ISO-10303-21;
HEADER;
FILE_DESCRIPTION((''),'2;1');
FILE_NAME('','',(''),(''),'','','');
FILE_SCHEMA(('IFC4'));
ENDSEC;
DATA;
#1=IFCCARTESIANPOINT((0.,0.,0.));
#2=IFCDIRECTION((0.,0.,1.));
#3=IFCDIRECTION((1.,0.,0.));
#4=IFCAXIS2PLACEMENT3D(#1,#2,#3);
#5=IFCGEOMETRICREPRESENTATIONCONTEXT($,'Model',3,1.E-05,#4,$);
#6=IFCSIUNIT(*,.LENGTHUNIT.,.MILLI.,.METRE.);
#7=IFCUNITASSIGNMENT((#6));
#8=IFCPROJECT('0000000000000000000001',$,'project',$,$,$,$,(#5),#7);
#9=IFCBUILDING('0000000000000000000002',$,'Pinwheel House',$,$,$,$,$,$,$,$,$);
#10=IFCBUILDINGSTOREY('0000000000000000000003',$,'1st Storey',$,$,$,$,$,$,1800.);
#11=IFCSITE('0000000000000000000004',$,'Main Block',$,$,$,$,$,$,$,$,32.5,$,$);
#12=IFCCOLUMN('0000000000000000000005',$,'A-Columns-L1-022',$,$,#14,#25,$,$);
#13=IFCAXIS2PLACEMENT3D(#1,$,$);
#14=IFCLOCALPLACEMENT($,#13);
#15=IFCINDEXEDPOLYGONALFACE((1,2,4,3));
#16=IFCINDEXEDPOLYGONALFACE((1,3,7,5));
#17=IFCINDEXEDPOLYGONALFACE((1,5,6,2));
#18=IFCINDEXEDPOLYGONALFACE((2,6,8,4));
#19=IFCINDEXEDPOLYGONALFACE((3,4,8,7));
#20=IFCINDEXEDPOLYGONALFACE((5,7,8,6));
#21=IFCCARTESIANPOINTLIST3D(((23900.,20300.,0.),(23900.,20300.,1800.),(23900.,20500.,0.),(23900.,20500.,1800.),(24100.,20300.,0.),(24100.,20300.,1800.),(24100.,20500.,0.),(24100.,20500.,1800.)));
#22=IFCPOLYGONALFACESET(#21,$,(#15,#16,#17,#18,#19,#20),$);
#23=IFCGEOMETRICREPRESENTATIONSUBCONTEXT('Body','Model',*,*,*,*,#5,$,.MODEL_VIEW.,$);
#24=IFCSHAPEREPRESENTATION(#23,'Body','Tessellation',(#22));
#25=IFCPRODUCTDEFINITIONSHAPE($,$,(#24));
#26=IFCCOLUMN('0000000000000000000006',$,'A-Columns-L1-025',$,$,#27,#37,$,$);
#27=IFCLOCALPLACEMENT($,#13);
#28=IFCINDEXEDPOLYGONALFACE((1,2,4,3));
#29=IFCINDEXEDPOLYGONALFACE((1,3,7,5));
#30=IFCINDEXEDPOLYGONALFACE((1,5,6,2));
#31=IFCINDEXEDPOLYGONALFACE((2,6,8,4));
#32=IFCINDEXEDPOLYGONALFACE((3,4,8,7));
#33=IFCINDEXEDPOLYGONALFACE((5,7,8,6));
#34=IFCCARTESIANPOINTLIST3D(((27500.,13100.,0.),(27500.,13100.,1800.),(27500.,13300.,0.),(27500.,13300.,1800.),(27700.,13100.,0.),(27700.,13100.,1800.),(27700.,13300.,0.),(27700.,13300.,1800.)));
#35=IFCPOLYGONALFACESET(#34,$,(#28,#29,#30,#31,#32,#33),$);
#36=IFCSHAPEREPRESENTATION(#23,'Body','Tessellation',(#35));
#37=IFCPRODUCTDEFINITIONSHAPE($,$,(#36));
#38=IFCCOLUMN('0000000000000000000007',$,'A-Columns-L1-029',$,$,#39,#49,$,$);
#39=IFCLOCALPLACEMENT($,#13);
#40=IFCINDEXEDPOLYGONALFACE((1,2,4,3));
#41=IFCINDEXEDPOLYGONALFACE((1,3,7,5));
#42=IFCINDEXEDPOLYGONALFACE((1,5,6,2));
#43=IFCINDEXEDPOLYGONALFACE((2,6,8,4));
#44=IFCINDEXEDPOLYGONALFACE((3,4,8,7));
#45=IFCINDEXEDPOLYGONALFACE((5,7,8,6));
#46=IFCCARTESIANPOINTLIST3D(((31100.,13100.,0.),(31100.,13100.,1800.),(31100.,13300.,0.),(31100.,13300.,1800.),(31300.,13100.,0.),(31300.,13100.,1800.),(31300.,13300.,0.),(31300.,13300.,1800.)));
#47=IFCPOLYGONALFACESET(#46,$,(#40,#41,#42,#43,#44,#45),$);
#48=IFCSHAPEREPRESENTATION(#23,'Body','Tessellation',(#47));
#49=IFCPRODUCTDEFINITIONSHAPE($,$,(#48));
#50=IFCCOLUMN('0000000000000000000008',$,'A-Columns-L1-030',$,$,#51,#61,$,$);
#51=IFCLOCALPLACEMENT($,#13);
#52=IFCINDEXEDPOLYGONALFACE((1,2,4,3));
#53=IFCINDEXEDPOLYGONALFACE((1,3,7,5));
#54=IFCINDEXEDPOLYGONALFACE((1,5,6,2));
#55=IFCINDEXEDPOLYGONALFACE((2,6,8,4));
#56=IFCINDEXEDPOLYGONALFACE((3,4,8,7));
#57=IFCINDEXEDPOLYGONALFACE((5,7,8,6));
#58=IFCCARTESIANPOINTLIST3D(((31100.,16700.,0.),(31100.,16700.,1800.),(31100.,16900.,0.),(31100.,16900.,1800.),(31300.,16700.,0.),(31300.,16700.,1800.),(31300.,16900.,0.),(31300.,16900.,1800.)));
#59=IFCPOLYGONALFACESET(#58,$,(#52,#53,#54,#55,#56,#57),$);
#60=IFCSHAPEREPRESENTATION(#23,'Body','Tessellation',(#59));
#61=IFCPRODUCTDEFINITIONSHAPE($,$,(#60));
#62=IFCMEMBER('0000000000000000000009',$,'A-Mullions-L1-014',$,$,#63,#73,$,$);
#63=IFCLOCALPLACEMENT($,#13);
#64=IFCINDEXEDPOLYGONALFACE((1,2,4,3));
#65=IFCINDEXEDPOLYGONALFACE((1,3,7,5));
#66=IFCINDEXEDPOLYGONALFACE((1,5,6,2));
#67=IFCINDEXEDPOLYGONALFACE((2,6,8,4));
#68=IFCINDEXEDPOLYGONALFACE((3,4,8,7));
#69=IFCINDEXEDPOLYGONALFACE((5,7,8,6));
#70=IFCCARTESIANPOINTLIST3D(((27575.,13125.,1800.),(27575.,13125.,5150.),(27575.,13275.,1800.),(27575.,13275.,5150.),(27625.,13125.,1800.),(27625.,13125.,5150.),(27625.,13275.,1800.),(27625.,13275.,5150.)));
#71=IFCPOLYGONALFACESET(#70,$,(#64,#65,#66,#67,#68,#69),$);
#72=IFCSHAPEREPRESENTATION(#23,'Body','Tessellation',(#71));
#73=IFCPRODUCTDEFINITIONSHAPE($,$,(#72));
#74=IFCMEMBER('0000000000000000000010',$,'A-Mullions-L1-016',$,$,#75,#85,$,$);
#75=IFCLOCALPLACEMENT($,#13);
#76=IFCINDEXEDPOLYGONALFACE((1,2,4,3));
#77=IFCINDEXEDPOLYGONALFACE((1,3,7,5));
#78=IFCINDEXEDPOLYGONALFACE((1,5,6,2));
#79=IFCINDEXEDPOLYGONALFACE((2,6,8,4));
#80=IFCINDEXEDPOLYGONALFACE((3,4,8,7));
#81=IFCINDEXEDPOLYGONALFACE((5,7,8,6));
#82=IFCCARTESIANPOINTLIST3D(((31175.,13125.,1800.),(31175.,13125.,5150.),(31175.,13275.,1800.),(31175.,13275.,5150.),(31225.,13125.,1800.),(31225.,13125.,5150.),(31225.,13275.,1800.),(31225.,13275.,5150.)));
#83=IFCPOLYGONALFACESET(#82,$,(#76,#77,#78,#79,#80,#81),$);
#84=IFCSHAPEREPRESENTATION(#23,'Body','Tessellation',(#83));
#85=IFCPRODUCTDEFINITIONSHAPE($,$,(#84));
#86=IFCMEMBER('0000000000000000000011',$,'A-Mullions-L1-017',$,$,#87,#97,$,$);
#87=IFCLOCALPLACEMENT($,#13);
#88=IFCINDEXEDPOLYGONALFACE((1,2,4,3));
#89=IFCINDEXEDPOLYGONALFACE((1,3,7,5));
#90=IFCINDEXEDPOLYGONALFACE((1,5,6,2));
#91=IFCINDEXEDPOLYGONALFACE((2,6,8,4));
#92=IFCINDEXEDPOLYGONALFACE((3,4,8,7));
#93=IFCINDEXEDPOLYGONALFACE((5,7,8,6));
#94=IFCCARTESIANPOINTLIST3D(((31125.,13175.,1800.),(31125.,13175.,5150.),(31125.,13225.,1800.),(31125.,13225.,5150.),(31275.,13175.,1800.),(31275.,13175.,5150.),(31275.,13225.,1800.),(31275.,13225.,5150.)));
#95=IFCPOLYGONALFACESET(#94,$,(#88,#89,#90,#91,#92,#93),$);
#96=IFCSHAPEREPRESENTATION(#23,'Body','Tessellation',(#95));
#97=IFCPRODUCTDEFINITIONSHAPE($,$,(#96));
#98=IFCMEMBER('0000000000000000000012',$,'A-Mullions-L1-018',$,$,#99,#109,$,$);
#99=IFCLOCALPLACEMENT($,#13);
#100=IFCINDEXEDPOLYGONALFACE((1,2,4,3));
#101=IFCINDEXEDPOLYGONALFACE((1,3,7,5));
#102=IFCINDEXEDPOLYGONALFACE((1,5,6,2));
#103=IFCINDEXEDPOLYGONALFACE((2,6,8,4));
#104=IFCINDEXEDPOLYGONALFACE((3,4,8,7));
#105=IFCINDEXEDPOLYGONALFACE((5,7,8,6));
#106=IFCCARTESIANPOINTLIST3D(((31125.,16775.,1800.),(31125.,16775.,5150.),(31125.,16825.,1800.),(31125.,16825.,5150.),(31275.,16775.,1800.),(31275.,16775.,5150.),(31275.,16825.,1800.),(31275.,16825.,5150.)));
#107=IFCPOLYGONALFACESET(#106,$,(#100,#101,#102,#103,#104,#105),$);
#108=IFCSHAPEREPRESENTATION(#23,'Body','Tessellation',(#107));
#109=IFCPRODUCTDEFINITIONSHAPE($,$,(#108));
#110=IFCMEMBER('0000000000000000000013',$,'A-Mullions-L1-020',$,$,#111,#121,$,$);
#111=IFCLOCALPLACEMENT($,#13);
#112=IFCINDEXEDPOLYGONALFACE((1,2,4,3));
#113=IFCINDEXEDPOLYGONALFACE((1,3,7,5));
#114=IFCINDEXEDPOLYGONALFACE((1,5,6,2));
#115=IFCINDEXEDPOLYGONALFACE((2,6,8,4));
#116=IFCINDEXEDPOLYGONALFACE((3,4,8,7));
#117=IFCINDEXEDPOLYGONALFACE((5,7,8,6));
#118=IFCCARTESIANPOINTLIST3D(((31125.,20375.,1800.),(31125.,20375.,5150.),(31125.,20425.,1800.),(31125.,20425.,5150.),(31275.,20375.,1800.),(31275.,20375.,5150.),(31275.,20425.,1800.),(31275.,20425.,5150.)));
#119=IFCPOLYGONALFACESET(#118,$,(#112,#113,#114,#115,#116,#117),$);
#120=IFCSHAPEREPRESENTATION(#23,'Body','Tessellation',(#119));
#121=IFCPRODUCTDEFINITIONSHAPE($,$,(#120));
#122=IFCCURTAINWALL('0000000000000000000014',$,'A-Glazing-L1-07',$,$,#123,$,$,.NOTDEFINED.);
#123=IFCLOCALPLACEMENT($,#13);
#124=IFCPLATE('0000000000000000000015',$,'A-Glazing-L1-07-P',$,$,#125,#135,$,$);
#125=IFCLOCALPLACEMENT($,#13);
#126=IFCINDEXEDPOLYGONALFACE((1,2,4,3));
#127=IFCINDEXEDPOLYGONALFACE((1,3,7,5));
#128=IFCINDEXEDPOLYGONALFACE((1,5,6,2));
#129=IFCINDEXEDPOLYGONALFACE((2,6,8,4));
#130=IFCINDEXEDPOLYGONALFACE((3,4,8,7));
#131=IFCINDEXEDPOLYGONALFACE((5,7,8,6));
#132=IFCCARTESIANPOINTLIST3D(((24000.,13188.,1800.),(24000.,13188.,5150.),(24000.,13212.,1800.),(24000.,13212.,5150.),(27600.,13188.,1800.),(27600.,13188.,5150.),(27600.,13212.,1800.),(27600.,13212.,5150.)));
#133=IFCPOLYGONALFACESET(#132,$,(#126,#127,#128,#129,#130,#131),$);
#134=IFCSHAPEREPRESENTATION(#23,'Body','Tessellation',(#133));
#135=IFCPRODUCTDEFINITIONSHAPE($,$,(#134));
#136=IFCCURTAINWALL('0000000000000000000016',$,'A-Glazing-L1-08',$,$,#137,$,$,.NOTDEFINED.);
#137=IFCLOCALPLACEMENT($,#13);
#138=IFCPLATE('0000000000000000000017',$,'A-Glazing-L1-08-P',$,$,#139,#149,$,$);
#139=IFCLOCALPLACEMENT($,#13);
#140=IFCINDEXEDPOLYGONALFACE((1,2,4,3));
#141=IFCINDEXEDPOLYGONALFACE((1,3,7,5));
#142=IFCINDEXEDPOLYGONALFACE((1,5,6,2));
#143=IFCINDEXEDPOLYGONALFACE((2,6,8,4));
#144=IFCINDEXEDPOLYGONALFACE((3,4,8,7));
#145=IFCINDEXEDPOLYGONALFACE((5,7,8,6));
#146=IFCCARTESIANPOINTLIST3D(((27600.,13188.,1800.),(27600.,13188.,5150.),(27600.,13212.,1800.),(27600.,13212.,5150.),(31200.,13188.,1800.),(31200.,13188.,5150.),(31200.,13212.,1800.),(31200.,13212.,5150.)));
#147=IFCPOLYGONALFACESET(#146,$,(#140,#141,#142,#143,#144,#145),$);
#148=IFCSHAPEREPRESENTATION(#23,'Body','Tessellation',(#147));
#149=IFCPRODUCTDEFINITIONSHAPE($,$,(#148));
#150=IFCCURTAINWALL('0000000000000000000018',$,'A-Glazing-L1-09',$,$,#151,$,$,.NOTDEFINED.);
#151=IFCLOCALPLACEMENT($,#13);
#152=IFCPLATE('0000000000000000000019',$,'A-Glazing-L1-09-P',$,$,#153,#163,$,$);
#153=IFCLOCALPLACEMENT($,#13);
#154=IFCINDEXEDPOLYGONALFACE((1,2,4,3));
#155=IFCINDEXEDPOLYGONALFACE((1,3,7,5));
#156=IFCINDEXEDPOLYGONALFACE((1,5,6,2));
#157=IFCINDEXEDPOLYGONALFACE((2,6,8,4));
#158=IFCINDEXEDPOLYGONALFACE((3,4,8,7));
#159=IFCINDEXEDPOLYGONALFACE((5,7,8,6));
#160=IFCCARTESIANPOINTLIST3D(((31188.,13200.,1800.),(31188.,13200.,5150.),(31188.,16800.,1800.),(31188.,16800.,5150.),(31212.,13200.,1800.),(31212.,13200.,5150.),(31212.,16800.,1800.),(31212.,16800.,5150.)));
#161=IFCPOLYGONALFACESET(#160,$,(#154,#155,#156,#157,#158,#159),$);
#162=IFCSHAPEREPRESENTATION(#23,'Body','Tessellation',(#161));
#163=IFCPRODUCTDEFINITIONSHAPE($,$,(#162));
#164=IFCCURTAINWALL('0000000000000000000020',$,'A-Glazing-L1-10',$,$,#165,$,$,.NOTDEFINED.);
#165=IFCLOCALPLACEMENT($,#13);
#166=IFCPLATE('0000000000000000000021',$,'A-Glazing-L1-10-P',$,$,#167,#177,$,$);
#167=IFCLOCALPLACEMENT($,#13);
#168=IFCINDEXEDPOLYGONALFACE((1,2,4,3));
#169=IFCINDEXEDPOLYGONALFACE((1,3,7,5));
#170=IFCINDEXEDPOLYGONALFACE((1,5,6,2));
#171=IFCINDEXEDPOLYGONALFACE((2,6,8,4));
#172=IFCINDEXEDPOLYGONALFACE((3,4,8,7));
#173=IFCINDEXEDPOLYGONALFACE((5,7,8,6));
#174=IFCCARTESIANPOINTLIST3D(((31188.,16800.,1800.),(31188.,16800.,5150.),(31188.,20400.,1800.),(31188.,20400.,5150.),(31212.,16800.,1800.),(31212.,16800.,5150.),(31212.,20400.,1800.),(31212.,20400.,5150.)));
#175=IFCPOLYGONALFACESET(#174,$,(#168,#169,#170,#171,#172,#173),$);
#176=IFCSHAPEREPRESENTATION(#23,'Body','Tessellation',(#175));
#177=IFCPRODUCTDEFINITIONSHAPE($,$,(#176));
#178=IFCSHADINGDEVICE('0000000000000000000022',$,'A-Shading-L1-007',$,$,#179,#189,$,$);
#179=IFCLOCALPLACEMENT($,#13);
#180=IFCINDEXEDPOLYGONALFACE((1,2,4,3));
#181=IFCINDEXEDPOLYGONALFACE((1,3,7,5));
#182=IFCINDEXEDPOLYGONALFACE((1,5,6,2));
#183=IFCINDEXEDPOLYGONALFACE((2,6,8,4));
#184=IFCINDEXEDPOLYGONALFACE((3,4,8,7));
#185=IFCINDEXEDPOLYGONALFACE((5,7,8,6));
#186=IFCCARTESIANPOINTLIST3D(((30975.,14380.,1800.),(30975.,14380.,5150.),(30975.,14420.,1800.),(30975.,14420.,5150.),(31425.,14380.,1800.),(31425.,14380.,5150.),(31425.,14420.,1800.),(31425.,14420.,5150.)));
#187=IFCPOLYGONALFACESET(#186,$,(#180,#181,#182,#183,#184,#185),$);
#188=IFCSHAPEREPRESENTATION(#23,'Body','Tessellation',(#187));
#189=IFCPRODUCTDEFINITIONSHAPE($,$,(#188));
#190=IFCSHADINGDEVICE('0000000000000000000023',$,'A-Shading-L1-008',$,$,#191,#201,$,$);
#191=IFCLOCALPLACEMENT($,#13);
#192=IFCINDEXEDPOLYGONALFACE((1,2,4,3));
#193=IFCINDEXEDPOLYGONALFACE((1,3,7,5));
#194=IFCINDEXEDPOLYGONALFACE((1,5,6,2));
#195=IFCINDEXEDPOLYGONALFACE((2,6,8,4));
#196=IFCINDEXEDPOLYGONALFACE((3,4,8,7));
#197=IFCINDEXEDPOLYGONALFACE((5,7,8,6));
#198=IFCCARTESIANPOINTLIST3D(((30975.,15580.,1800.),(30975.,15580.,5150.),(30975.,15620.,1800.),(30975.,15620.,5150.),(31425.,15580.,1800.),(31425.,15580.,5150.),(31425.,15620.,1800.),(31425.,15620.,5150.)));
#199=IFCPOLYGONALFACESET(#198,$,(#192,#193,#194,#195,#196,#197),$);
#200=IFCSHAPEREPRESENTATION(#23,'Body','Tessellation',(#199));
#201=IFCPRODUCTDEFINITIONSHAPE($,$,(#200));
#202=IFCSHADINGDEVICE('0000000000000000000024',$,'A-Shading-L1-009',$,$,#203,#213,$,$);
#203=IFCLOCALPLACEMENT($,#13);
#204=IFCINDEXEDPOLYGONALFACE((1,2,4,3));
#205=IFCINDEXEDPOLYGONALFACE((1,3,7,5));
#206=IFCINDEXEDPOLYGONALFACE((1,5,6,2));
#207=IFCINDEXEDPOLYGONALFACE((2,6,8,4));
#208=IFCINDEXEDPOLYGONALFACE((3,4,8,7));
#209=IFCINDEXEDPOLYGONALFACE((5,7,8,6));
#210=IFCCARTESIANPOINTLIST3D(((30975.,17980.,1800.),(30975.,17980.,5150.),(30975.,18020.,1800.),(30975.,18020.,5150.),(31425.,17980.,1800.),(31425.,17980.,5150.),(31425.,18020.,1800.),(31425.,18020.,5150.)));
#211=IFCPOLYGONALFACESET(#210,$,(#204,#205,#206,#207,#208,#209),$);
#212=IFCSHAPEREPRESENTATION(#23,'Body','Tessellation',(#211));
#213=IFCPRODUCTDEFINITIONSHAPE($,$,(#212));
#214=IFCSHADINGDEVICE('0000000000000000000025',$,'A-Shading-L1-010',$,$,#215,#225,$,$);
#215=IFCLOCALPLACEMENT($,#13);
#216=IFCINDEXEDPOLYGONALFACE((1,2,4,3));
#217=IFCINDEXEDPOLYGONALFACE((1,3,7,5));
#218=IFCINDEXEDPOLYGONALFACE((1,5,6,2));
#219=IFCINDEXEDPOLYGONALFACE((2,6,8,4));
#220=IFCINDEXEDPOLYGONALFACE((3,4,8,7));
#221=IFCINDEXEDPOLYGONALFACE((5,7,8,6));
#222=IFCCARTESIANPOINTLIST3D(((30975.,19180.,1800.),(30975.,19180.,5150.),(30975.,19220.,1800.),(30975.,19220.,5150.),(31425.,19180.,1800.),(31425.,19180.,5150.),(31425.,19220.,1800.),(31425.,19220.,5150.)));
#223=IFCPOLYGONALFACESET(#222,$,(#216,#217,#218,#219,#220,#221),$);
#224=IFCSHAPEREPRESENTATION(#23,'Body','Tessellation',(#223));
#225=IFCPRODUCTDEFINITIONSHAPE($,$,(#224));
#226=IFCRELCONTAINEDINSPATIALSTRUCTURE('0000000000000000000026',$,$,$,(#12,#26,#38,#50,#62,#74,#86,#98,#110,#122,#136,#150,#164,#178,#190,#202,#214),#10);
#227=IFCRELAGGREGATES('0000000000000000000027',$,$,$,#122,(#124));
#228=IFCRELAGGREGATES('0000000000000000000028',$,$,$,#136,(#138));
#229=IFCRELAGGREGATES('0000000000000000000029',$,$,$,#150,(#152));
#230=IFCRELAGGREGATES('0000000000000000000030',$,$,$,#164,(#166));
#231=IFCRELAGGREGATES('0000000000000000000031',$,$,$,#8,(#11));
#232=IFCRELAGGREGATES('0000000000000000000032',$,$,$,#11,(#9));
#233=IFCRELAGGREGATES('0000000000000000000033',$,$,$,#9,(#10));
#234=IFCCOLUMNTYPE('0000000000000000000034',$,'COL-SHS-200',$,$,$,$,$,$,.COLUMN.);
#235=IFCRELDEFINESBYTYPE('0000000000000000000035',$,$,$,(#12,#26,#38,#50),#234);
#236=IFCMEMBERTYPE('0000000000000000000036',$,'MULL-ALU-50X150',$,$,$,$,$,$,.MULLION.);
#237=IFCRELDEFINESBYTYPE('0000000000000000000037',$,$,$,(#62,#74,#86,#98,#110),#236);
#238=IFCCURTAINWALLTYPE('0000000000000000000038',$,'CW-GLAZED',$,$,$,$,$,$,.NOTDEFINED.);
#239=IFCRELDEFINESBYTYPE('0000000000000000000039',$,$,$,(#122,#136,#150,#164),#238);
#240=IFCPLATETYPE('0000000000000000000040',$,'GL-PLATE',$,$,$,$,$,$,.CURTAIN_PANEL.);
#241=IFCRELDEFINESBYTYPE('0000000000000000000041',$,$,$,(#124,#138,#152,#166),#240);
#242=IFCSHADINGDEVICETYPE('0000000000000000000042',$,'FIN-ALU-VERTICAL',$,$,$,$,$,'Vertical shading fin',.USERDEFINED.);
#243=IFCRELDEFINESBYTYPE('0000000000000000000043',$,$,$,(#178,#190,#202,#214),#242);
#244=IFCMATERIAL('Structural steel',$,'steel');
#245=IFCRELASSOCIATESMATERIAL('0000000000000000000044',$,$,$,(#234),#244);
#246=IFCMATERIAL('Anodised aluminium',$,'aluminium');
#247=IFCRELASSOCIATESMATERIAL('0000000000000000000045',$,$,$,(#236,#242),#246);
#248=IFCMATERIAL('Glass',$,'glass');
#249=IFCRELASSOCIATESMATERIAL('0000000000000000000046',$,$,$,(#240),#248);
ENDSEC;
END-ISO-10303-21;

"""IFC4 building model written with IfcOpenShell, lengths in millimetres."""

from ifc_helpers import new_model, si_unit, frame, origin_with_axes, place, context, subcontext, project, spatial, indexed_curve, outline, extrude, material, type_object, element, aggregate, save


model = new_model("IFC4")

# Units and contexts
model_context = context("Model", 3, precision=1e-05, world=origin_with_axes())
body_context = subcontext(model_context, "Body", "Model", "MODEL_VIEW")
ifc_project = project(units=[si_unit("LENGTHUNIT", "METRE", prefix="MILLI")], contexts=[model_context])

# Site, building, storey
site = spatial("IfcSite", under=ifc_project, Name="Main Block", RefElevation=32.5)
building = spatial("IfcBuilding", under=site, Name="Pinwheel House")
storey = spatial("IfcBuildingStorey", under=building, Name="1st Storey", Elevation=1800.0)

# Columns
ifc_material_1 = material(Name="Structural steel", Category="steel")
column_type = type_object("IfcColumnType", Name="COL-SHS-200", PredefinedType="COLUMN", material=ifc_material_1)
for number, where, z_axis, x_axis, name in (
    (1, (24000.0, 20400.0, 0.0), (0.0, 0.0, 1.0), (1.0, 0.0, 0.0), "A-Columns-L1-022"),
    (2, (27600.0, 13200.0, 0.0), (0.0, 0.0, 1.0), (1.0, 0.0, 0.0), "A-Columns-L1-025"),
    (3, (31200.0, 13200.0, 0.0), (0.0, 0.0, 1.0), (1.0, 0.0, 0.0), "A-Columns-L1-029"),
    (4, (31200.0, 16800.0, 0.0), (0.0, 0.0, 1.0), (1.0, 0.0, 0.0), "A-Columns-L1-030"),
):
    element("IfcColumn", number, at=place(None, frame(where, z_axis=z_axis, x_axis=x_axis)), inside=storey, type_object=column_type, Name=name, context=body_context, shape_type="SweptSolid", body=[
        extrude(outline(indexed_curve([(-100.0, -100.0), (100.0, -100.0), (100.0, 100.0), (-100.0, 100.0)])), None, (0.0, 0.0, 1.0), 1800.0),
    ])

# Members
ifc_material_2 = material(Name="Anodised aluminium", Category="aluminium")
member_type = type_object("IfcMemberType", Name="MULL-ALU-50X150", PredefinedType="MULLION", material=ifc_material_2)
for number, where, z_axis, x_axis, name in (
    (5, (27600.0, 13200.0, 1800.0), (0.0, 0.0, 1.0), (1.0, 0.0, 0.0), "A-Mullions-L1-014"),
    (6, (31200.0, 13200.0, 1800.0), (0.0, 0.0, 1.0), (1.0, 0.0, 0.0), "A-Mullions-L1-016"),
    (7, (31200.0, 13200.0, 1800.0), (0.0, 0.0, 1.0), (0.0, 1.0, 0.0), "A-Mullions-L1-017"),
    (8, (31200.0, 16800.0, 1800.0), (0.0, 0.0, 1.0), (0.0, 1.0, 0.0), "A-Mullions-L1-018"),
    (9, (31200.0, 20400.0, 1800.0), (0.0, 0.0, 1.0), (0.0, 1.0, 0.0), "A-Mullions-L1-020"),
):
    element("IfcMember", number, at=place(None, frame(where, z_axis=z_axis, x_axis=x_axis)), inside=storey, type_object=member_type, Name=name, context=body_context, shape_type="SweptSolid", body=[
        extrude(outline(indexed_curve([(-25.0, -75.0), (25.0, -75.0), (25.0, 75.0), (-25.0, 75.0)])), None, (0.0, 0.0, 1.0), 3350.0),
    ])

# Curtain walls, plates
curtain_wall_type = type_object("IfcCurtainWallType", Name="CW-GLAZED", PredefinedType="NOTDEFINED")
curtain_wall_1 = element("IfcCurtainWall", 10, inside=storey, type_object=curtain_wall_type, Name="A-Glazing-L1-07", PredefinedType="NOTDEFINED")
ifc_material_3 = material(Name="Glass", Category="glass")
plate_type = type_object("IfcPlateType", Name="GL-PLATE", PredefinedType="CURTAIN_PANEL", material=ifc_material_3)
plate_1_placement = place(None, frame((25800.0, 13200.0, 1800.0), z_axis=(0.0, 0.0, 1.0), x_axis=(1.0, 0.0, 0.0)))
plate_1 = element("IfcPlate", 11, at=plate_1_placement, type_object=plate_type, Name="A-Glazing-L1-07-P", context=body_context, shape_type="SweptSolid", body=[
    extrude(outline(indexed_curve([(-1800.0, -12.0), (1800.0, -12.0), (1800.0, 12.0), (-1800.0, 12.0)])), None, (0.0, 0.0, 1.0), 3350.0),
])
aggregate(curtain_wall_1, [plate_1])
curtain_wall_2 = element("IfcCurtainWall", 12, inside=storey, type_object=curtain_wall_type, Name="A-Glazing-L1-08", PredefinedType="NOTDEFINED")
plate_2_placement = place(None, frame((29400.0, 13200.0, 1800.0), z_axis=(0.0, 0.0, 1.0), x_axis=(1.0, 0.0, 0.0)))
plate_2 = element("IfcPlate", 13, at=plate_2_placement, type_object=plate_type, Name="A-Glazing-L1-08-P", context=body_context, shape_type="SweptSolid", body=[
    extrude(outline(indexed_curve([(-1800.0, -12.0), (1800.0, -12.0), (1800.0, 12.0), (-1800.0, 12.0)])), None, (0.0, 0.0, 1.0), 3350.0),
])
aggregate(curtain_wall_2, [plate_2])
curtain_wall_3 = element("IfcCurtainWall", 14, inside=storey, type_object=curtain_wall_type, Name="A-Glazing-L1-09", PredefinedType="NOTDEFINED")
plate_3_placement = place(None, frame((31200.0, 15000.0, 1800.0), z_axis=(0.0, 0.0, 1.0), x_axis=(0.0, 1.0, 0.0)))
plate_3 = element("IfcPlate", 15, at=plate_3_placement, type_object=plate_type, Name="A-Glazing-L1-09-P", context=body_context, shape_type="SweptSolid", body=[
    extrude(outline(indexed_curve([(-1800.0, -12.0), (1800.0, -12.0), (1800.0, 12.0), (-1800.0, 12.0)])), None, (0.0, 0.0, 1.0), 3350.0),
])
aggregate(curtain_wall_3, [plate_3])
curtain_wall_4 = element("IfcCurtainWall", 16, inside=storey, type_object=curtain_wall_type, Name="A-Glazing-L1-10", PredefinedType="NOTDEFINED")
plate_4_placement = place(None, frame((31200.0, 18600.0, 1800.0), z_axis=(0.0, 0.0, 1.0), x_axis=(0.0, 1.0, 0.0)))
plate_4 = element("IfcPlate", 17, at=plate_4_placement, type_object=plate_type, Name="A-Glazing-L1-10-P", context=body_context, shape_type="SweptSolid", body=[
    extrude(outline(indexed_curve([(-1800.0, -12.0), (1800.0, -12.0), (1800.0, 12.0), (-1800.0, 12.0)])), None, (0.0, 0.0, 1.0), 3350.0),
])
aggregate(curtain_wall_4, [plate_4])

# Shading devices
shading_device_type = type_object("IfcShadingDeviceType", Name="FIN-ALU-VERTICAL", ElementType="Vertical shading fin", PredefinedType="USERDEFINED", material=ifc_material_2)
for number, where, z_axis, x_axis, name in (
    (18, (31200.0, 14400.0, 1800.0), (0.0, 0.0, 1.0), (0.0, 1.0, 0.0), "A-Shading-L1-007"),
    (19, (31200.0, 15600.0, 1800.0), (0.0, 0.0, 1.0), (0.0, 1.0, 0.0), "A-Shading-L1-008"),
    (20, (31200.0, 18000.0, 1800.0), (0.0, 0.0, 1.0), (0.0, 1.0, 0.0), "A-Shading-L1-009"),
    (21, (31200.0, 19200.0, 1800.0), (0.0, 0.0, 1.0), (0.0, 1.0, 0.0), "A-Shading-L1-010"),
):
    element("IfcShadingDevice", number, at=place(None, frame(where, z_axis=z_axis, x_axis=x_axis)), inside=storey, type_object=shading_device_type, Name=name, context=body_context, shape_type="SweptSolid", body=[
        extrude(outline(indexed_curve([(-20.0, -225.0), (20.0, -225.0), (20.0, 225.0), (-20.0, 225.0)])), None, (0.0, 0.0, 1.0), 3350.0),
    ])

save(model, "model.ifc")
